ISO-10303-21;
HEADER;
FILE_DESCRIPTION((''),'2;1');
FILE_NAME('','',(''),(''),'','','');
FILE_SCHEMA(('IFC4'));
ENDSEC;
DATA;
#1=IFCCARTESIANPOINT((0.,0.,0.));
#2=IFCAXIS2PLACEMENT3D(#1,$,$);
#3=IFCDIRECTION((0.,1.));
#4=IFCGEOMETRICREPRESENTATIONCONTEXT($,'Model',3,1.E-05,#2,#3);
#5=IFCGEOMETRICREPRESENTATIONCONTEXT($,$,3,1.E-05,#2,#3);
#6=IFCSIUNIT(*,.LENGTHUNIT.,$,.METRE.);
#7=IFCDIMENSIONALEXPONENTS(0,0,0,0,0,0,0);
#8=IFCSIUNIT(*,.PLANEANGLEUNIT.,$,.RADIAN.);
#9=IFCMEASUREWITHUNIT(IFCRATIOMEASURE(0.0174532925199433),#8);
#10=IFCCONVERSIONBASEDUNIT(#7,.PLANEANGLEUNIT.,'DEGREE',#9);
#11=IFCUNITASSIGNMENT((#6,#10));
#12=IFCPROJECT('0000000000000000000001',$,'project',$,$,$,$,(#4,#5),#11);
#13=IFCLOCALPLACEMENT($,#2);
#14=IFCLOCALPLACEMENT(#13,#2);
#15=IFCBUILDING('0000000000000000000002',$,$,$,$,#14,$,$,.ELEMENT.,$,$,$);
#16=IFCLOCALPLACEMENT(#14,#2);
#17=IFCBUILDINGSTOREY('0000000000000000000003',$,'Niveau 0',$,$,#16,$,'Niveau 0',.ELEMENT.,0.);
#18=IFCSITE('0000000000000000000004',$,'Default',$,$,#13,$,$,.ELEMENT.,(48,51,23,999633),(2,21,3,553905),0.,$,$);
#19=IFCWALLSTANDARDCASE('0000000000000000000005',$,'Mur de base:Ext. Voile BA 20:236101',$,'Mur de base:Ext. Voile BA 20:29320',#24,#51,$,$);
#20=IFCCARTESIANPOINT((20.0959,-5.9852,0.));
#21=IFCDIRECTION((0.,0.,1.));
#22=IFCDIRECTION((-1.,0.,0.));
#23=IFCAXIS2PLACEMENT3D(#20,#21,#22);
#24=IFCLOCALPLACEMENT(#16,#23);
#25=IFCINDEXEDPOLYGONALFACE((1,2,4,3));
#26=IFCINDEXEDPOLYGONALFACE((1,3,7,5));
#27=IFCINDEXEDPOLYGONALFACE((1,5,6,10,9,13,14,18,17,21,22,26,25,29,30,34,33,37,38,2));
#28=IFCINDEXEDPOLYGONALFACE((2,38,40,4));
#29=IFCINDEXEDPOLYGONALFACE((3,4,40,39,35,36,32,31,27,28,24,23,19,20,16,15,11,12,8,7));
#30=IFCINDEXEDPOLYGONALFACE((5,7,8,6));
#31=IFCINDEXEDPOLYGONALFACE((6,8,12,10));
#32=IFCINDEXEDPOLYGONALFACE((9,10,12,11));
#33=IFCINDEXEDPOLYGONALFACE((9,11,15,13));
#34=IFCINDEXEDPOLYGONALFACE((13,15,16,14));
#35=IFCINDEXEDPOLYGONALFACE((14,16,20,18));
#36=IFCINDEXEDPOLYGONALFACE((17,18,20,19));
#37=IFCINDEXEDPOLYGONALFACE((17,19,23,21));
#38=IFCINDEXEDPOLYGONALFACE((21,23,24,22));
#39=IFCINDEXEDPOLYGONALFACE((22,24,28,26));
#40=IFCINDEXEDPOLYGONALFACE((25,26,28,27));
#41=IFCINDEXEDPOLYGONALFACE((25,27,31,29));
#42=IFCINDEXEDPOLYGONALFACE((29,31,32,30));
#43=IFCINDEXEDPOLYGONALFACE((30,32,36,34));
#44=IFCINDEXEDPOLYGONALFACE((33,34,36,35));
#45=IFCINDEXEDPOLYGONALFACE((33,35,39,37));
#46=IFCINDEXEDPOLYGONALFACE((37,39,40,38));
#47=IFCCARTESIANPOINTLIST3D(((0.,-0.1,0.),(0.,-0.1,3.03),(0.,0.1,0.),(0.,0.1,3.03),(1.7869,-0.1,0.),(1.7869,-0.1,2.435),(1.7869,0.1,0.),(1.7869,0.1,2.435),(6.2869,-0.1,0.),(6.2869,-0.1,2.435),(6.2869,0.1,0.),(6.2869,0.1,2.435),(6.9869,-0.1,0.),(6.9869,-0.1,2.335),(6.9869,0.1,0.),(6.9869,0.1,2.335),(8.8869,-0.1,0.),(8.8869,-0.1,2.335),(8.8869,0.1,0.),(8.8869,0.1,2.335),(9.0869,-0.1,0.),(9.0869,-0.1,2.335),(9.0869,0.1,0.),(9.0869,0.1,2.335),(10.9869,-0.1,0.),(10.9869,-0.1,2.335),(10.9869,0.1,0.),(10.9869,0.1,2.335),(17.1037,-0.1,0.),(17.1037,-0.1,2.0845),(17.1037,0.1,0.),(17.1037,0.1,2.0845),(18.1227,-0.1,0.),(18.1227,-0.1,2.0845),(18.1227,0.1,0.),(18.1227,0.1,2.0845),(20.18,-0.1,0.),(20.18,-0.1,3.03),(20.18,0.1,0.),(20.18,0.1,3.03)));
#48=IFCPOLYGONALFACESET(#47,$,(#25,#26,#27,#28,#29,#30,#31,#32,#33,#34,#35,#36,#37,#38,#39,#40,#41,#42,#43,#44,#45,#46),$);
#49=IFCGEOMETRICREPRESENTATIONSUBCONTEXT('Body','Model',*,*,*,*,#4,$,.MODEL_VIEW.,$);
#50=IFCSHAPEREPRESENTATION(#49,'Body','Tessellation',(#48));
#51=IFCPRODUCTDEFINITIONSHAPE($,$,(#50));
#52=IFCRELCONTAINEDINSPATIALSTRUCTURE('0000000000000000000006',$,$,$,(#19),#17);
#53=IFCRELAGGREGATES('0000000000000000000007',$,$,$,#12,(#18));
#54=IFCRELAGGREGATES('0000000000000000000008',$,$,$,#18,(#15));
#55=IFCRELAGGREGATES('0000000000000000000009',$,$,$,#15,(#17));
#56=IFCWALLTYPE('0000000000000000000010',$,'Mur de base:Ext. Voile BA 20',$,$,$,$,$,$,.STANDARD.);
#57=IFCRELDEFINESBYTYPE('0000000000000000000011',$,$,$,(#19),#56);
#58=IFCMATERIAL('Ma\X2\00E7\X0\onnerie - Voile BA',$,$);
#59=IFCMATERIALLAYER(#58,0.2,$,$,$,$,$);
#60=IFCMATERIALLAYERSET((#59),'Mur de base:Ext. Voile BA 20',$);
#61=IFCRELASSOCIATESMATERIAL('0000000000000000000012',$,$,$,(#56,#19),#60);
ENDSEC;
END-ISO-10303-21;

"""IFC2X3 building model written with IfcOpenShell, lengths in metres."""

from ifc_helpers import new_model, entity, si_unit, converted_unit, direction, frame, frame_2d, origin, origin_2d_with_axis, place, context, subcontext, project, spatial, rectangle, extrude, material, layer, layer_set, layer_usage, type_object, element, save


model = new_model("IFC2X3")

# Units and contexts
model_context = context("Model", 3, precision=1e-05, world=origin(), true_north=direction((0.0, 1.0)))
context_of_model = context(None, 3, precision=1e-05, world=origin(), true_north=direction((0.0, 1.0)))
body_context = subcontext(model_context, "Body", "Model", "MODEL_VIEW")
ifc_project = project(units=[si_unit("LENGTHUNIT", "METRE"), converted_unit("PLANEANGLEUNIT", "DEGREE", entity("IfcRatioMeasure", 0.0174532925199433), si_unit("PLANEANGLEUNIT", "RADIAN"), dimensions=[0, 0, 0, 0, 0, 0, 0])], contexts=[model_context, context_of_model])

# Site, building, storey
site_placement = place(None, origin())
site = spatial("IfcSite", under=ifc_project, at=site_placement, Name="Default", CompositionType="ELEMENT", RefLatitude=(48, 51, 23, 999633), RefLongitude=(2, 21, 3, 553905), RefElevation=0.0)
building_placement = place(site_placement, origin())
building = spatial("IfcBuilding", under=site, at=building_placement, CompositionType="ELEMENT")
storey_placement = place(building_placement, origin())
storey = spatial("IfcBuildingStorey", under=building, at=storey_placement, Name="Niveau 0", LongName="Niveau 0", CompositionType="ELEMENT", Elevation=0.0)

# Wall, openings
ifc_material = material(Name="Maçonnerie - Voile BA")
ifc_layer = layer(ifc_material, 0.2)
ifc_layer_set = layer_set([ifc_layer], Name="Mur de base:Ext. Voile BA 20")
ifc_layer_usage_1 = layer_usage(ifc_layer_set, "AXIS2", "NEGATIVE", 0.1)
wall_type = type_object("IfcWallType", Name="Mur de base:Ext. Voile BA 20", PredefinedType="STANDARD", material=ifc_layer_set)
wall_1_placement = place(storey_placement, frame((20.0959, -5.9852, 0.0), z_axis=(0.0, 0.0, 1.0), x_axis=(-1.0, 0.0, 0.0)))
wall_1 = element("IfcWallStandardCase", 1, at=wall_1_placement, inside=storey, type_object=wall_type, material=ifc_layer_usage_1, Name="Mur de base:Ext. Voile BA 20:236101", ObjectType="Mur de base:Ext. Voile BA 20:29320", context=body_context, shape_type="SweptSolid", body=[
    extrude(rectangle(XDim=20.18, YDim=0.2, at=frame_2d((10.09, 0.0), x_axis=(-1.0, 0.0))), origin(), (0.0, 0.0, 1.0), 3.03),
])
opening_1_placement = place(wall_1_placement, origin())
element("IfcOpeningElement", 2, at=opening_1_placement, cuts=wall_1, ObjectType="Opening", context=body_context, shape_type="SweptSolid", body=[
    extrude(rectangle(XDim=2.0845, YDim=1.019, at=origin_2d_with_axis()), frame((17.6132, -0.1, 1.0422), z_axis=(0.0, 1.0, 0.0), x_axis=(0.0, 0.0, -1.0)), (0.0, 0.0, 1.0), 0.2),
])
opening_2_placement = place(wall_1_placement, origin())
element("IfcOpeningElement", 3, at=opening_2_placement, cuts=wall_1, ObjectType="Opening", context=body_context, shape_type="SweptSolid", body=[
    extrude(rectangle(XDim=2.365, YDim=1.9, at=origin_2d_with_axis()), frame((10.0369, -0.1, 1.1525), z_axis=(0.0, 1.0, 0.0), x_axis=(0.0, 0.0, -1.0)), (0.0, 0.0, 1.0), 0.2),
])
opening_3_placement = place(wall_1_placement, origin())
element("IfcOpeningElement", 4, at=opening_3_placement, cuts=wall_1, ObjectType="Opening", context=body_context, shape_type="SweptSolid", body=[
    extrude(rectangle(XDim=2.365, YDim=1.9, at=origin_2d_with_axis()), frame((7.9369, -0.1, 1.1525), z_axis=(0.0, 1.0, 0.0), x_axis=(0.0, 0.0, -1.0)), (0.0, 0.0, 1.0), 0.2),
])
opening_4_placement = place(wall_1_placement, origin())
element("IfcOpeningElement", 5, at=opening_4_placement, cuts=wall_1, ObjectType="Opening", context=body_context, shape_type="SweptSolid", body=[
    extrude(rectangle(XDim=2.465, YDim=4.5, at=origin_2d_with_axis()), frame((4.0369, -0.1, 1.2025), z_axis=(0.0, 1.0, 0.0), x_axis=(0.0, 0.0, -1.0)), (0.0, 0.0, 1.0), 0.2),
])

save(model, "model.ifc")
